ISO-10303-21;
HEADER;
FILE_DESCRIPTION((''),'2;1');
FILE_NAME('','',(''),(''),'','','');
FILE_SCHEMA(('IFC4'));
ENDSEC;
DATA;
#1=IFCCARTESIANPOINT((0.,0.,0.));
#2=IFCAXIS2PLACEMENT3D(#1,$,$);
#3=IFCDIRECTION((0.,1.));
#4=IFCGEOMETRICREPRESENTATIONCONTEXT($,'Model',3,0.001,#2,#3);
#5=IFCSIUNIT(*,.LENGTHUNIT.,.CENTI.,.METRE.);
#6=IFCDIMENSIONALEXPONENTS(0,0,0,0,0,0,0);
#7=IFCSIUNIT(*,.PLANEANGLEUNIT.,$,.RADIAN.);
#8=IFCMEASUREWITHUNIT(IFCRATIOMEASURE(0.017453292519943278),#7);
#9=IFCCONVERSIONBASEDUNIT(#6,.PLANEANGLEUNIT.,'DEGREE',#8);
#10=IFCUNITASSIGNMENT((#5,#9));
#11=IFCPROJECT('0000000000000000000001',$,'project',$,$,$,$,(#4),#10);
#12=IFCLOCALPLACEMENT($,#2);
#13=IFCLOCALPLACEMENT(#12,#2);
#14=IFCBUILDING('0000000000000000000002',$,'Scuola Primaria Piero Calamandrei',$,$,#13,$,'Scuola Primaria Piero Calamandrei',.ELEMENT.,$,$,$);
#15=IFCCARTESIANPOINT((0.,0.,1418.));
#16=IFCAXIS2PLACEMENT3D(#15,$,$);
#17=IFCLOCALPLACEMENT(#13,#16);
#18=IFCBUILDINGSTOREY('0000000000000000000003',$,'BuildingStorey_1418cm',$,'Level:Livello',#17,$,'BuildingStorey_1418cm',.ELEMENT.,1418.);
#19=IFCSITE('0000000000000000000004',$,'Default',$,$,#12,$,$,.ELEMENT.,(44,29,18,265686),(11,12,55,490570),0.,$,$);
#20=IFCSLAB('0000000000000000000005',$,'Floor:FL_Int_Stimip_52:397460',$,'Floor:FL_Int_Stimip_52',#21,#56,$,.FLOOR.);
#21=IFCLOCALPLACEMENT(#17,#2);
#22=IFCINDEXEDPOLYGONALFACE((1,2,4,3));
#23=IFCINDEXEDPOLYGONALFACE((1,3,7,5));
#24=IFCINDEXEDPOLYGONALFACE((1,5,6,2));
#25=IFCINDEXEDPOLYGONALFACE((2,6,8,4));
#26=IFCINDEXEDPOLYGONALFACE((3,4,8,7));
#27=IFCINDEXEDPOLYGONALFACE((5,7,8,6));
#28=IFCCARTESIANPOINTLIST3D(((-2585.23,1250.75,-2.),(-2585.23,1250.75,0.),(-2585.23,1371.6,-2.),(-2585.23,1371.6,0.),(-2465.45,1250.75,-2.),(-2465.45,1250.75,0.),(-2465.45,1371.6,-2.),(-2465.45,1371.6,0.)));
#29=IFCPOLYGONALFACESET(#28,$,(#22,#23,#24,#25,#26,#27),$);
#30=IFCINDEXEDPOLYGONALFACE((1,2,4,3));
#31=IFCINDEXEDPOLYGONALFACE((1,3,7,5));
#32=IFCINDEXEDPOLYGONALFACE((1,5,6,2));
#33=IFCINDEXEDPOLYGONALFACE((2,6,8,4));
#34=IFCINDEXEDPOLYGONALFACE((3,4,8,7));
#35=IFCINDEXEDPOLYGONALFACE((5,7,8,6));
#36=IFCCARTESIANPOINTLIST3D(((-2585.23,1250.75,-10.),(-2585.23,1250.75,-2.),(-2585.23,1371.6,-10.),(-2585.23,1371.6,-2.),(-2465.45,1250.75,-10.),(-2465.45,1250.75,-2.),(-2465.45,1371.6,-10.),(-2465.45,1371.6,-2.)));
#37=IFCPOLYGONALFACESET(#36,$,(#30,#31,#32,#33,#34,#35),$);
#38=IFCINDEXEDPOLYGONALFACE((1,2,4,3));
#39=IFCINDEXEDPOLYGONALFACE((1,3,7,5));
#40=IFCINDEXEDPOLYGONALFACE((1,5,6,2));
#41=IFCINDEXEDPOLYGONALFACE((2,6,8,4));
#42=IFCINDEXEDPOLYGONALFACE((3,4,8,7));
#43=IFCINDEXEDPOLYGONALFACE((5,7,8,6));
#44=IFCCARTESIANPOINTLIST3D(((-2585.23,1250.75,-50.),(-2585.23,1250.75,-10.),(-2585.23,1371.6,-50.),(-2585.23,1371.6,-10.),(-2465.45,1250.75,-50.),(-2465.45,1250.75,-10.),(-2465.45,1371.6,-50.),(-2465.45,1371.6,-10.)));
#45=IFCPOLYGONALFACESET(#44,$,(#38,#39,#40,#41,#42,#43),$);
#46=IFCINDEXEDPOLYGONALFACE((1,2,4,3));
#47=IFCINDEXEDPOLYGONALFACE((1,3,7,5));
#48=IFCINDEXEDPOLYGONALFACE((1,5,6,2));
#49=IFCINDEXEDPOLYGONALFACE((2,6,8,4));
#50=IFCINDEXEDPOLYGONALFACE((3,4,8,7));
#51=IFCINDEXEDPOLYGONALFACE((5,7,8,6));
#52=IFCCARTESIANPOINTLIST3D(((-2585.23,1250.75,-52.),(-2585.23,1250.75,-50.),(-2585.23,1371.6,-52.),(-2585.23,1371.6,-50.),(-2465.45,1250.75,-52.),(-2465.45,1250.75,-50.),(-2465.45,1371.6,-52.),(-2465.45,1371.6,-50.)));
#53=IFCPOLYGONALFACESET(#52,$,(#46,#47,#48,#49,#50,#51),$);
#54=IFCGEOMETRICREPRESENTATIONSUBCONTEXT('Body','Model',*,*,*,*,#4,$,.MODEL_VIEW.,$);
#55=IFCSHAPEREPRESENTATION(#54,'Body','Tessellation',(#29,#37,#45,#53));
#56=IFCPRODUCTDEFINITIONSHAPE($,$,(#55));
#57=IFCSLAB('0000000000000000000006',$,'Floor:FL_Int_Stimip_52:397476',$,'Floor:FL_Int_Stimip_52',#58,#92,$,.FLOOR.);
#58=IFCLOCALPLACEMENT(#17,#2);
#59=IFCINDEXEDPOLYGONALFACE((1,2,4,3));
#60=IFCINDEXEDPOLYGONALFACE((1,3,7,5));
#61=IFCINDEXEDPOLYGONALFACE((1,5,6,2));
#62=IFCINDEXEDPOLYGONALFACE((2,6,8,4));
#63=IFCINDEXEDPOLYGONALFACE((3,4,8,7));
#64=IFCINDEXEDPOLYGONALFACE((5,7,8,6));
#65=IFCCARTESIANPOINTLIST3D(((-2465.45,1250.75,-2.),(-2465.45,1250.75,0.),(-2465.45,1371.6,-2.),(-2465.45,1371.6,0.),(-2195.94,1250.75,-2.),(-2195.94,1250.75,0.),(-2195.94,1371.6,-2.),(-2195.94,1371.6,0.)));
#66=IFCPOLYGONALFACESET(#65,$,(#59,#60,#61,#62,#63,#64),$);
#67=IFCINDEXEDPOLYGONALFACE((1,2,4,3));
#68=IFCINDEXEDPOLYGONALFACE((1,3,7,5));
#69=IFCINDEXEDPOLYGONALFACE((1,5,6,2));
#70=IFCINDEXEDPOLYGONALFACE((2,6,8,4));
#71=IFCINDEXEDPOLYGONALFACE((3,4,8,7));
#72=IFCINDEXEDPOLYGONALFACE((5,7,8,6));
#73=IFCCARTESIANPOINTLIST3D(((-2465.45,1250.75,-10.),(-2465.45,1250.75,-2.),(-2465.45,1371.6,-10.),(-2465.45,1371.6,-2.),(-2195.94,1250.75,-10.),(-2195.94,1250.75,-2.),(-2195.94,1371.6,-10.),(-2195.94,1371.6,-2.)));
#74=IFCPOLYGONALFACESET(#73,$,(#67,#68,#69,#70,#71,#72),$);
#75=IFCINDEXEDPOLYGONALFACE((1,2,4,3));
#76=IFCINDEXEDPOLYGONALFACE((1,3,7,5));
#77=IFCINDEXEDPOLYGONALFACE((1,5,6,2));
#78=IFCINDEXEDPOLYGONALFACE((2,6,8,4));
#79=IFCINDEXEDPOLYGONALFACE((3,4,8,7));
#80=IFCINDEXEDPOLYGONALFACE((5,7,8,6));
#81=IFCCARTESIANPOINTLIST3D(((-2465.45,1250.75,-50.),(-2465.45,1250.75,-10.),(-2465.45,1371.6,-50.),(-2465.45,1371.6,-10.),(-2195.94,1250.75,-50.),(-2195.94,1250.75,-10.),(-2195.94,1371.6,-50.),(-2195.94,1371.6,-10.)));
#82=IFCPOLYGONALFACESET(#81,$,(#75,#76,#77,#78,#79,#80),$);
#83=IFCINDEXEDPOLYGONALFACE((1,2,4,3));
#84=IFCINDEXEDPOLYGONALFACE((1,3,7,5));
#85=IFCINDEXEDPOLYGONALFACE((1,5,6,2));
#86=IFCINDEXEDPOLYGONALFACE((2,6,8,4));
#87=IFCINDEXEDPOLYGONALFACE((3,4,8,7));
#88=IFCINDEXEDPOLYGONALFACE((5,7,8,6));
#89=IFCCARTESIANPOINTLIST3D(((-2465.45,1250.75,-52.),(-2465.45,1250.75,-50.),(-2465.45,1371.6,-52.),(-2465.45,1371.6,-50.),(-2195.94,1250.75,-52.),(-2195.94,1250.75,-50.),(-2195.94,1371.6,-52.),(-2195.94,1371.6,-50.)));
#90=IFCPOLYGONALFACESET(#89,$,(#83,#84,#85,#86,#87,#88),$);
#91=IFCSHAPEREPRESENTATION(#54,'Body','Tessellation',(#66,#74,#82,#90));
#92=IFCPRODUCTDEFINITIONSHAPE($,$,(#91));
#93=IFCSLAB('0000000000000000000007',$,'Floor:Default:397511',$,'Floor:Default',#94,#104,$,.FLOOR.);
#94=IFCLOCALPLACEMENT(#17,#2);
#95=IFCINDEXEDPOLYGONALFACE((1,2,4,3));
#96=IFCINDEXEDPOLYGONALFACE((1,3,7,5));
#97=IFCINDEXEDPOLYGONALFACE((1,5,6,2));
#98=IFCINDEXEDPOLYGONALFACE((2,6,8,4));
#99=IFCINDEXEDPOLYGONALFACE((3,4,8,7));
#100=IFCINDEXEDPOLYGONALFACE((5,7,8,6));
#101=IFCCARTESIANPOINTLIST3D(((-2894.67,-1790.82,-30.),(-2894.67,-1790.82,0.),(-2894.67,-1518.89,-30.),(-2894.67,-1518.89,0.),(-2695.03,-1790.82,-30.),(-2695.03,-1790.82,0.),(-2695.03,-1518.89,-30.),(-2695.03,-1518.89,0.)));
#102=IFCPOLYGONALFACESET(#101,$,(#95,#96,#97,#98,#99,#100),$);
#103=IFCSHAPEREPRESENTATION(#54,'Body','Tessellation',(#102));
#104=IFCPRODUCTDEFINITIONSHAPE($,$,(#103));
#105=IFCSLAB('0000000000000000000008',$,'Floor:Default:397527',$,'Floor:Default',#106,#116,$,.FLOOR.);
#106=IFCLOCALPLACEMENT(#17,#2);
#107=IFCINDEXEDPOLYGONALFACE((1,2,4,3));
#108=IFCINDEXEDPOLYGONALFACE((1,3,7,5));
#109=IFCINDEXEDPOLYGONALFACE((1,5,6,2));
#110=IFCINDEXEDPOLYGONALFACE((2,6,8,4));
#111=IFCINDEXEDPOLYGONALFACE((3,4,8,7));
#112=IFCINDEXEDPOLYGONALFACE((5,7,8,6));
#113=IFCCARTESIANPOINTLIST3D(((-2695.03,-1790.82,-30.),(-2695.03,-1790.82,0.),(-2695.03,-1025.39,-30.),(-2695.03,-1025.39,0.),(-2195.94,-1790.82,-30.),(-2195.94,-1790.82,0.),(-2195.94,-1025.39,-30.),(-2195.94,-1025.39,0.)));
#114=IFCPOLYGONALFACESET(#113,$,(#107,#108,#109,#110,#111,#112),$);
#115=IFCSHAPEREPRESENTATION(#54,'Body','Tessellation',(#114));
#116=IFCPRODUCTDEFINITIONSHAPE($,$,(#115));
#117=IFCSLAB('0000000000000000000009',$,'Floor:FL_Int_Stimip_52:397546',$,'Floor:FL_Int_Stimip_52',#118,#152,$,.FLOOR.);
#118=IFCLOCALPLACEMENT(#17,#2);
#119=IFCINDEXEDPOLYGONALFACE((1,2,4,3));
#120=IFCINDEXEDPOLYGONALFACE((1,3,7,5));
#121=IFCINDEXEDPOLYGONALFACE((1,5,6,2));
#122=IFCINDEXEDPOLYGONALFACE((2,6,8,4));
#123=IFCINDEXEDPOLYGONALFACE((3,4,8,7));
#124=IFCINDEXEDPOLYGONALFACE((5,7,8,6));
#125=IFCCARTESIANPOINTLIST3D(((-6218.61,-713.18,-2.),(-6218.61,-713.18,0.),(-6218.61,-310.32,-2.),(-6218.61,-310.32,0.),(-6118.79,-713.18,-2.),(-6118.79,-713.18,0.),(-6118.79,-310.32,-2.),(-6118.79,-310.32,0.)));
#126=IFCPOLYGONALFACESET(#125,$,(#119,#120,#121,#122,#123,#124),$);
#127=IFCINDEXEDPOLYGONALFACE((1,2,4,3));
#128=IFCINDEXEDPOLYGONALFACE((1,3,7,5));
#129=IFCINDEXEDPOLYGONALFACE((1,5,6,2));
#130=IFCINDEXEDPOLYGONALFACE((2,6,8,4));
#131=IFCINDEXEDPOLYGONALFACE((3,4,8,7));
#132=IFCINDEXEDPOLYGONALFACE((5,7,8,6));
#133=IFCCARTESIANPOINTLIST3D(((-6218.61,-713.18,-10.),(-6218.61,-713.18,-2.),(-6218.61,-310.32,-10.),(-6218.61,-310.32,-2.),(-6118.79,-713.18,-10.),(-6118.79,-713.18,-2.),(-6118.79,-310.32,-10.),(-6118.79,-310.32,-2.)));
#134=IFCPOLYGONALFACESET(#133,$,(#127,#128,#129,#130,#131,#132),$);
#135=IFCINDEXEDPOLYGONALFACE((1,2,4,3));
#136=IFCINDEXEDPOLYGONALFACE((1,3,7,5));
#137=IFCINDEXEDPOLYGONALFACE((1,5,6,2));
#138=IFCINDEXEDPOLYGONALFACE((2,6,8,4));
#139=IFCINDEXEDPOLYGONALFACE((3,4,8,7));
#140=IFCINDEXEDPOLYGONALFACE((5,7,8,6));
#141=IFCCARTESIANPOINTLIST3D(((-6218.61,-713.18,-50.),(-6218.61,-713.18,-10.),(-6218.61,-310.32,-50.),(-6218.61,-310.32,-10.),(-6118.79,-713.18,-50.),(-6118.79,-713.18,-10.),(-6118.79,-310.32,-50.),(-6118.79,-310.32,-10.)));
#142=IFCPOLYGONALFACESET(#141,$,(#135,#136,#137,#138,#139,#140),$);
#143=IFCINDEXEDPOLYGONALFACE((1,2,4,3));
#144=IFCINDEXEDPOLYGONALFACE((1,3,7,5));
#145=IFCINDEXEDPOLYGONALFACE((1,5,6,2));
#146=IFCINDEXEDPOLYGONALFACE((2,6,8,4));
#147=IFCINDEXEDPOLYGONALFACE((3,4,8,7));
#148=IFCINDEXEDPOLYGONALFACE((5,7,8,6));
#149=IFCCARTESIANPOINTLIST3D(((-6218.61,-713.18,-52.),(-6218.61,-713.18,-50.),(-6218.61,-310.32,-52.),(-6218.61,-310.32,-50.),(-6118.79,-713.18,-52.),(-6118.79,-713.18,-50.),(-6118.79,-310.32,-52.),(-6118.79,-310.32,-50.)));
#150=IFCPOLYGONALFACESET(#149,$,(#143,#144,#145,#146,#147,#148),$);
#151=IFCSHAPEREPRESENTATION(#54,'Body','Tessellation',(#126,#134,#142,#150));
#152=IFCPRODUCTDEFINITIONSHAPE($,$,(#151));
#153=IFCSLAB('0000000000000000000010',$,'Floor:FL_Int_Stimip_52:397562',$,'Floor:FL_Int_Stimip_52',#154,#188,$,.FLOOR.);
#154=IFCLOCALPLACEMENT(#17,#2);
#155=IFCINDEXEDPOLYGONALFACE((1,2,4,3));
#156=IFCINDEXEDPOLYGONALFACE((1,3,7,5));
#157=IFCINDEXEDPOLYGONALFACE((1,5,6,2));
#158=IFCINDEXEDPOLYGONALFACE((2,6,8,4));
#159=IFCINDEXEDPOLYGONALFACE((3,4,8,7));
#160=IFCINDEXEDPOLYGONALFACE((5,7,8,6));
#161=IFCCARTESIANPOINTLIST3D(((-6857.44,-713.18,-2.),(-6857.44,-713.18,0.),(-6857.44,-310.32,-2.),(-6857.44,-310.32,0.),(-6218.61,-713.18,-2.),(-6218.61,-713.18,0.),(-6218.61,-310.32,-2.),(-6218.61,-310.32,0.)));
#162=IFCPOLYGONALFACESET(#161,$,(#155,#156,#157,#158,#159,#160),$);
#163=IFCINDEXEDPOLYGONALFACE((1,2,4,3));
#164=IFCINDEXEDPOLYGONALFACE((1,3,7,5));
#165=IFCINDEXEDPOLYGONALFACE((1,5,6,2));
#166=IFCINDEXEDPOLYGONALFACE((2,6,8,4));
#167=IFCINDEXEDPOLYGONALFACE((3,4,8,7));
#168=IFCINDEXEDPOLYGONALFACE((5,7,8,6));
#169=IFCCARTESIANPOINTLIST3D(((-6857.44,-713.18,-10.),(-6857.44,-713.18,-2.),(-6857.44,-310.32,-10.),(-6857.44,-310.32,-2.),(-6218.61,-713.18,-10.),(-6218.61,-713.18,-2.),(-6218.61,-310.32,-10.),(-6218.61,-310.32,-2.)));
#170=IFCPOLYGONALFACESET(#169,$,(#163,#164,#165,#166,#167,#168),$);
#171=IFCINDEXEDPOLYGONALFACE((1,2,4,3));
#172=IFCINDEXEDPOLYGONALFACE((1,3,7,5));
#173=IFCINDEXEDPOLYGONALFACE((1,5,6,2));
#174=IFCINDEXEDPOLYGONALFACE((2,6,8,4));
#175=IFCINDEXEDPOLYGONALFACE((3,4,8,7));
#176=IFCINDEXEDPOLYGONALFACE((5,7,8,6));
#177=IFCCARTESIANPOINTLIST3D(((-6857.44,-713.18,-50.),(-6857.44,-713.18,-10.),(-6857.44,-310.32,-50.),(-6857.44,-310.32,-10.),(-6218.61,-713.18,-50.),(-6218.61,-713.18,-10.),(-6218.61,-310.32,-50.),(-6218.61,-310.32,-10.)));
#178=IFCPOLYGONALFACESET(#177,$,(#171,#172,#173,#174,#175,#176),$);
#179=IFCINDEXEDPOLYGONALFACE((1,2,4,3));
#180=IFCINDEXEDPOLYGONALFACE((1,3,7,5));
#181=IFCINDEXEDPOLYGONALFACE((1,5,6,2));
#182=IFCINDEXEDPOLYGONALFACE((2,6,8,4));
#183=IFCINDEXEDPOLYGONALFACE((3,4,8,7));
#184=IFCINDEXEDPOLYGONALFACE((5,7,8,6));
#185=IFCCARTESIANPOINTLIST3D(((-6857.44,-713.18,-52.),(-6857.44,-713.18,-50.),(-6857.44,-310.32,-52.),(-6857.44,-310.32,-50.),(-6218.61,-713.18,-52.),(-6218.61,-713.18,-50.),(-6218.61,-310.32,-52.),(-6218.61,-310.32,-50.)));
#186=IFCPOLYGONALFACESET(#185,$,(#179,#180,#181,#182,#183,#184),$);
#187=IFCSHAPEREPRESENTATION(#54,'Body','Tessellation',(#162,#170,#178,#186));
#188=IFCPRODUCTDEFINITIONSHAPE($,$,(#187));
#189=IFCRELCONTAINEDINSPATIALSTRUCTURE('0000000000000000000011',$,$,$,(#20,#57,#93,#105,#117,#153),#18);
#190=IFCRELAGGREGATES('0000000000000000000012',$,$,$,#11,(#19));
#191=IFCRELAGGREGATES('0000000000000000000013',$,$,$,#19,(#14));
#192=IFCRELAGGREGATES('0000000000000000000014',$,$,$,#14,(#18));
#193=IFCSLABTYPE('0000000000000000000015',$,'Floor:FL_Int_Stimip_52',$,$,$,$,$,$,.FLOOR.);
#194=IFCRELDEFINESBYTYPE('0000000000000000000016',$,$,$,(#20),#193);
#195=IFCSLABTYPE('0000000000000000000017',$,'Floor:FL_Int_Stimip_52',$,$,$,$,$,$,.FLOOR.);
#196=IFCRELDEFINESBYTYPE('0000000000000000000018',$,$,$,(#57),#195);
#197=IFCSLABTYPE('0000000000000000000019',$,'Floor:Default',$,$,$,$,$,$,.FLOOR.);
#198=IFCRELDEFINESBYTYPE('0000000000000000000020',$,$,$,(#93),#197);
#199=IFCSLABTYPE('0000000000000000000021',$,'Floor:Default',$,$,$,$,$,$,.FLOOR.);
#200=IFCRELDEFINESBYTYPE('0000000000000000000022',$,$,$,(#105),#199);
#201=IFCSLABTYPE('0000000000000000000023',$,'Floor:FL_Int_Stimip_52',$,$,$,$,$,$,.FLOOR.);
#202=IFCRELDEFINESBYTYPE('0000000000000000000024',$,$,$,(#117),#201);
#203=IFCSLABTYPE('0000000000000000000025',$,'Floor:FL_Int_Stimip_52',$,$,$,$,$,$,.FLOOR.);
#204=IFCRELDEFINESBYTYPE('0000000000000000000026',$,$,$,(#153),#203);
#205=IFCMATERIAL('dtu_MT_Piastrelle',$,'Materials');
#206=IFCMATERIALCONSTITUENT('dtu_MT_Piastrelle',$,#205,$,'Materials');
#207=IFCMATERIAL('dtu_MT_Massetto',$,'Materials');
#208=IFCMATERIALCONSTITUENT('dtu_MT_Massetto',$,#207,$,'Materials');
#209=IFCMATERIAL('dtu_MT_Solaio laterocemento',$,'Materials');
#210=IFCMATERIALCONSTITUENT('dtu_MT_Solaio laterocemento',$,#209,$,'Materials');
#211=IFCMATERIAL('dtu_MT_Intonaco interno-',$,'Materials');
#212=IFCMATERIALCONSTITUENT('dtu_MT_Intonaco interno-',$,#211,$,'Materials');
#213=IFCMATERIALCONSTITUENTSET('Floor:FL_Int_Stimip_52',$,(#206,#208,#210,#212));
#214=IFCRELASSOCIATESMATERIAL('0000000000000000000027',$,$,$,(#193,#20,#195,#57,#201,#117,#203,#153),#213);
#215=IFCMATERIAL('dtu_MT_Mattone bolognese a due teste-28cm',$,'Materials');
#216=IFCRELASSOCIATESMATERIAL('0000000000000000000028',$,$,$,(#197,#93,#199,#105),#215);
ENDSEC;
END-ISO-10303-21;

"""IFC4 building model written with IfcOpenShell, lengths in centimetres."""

from ifc_helpers import new_model, entity, si_unit, converted_unit, direction, frame, origin, place, context, subcontext, project, spatial, indexed_curve, outline, extrude, material, constituent, constituent_set, type_object, element, save


model = new_model("IFC4")

# Units and contexts
model_context = context("Model", 3, precision=0.001, world=origin(), true_north=direction((0.0, 1.0)))
body_context = subcontext(model_context, "Body", "Model", "MODEL_VIEW")
ifc_project = project(units=[si_unit("LENGTHUNIT", "METRE", prefix="CENTI"), converted_unit("PLANEANGLEUNIT", "DEGREE", entity("IfcRatioMeasure", 0.017453292519943278), si_unit("PLANEANGLEUNIT", "RADIAN"), dimensions=[0, 0, 0, 0, 0, 0, 0])], contexts=[model_context])

# Site, building, storey
site_placement = place(None, origin())
site = spatial("IfcSite", under=ifc_project, at=site_placement, Name="Default", CompositionType="ELEMENT", RefLatitude=(44, 29, 18, 265686), RefLongitude=(11, 12, 55, 490570), RefElevation=0.0)
building_placement = place(site_placement, origin())
building = spatial("IfcBuilding", under=site, at=building_placement, Name="Scuola Primaria Piero Calamandrei", LongName="Scuola Primaria Piero Calamandrei", CompositionType="ELEMENT")
storey_placement = place(building_placement, frame((0.0, 0.0, 1418.0)))
storey = spatial("IfcBuildingStorey", under=building, at=storey_placement, Name="BuildingStorey_1418cm", ObjectType="Level:Livello", LongName="BuildingStorey_1418cm", CompositionType="ELEMENT", Elevation=1418.0)

# Slabs
ifc_material_1 = material(Name="dtu_MT_Piastrelle", Category="Materials")
ifc_constituent_1 = constituent(ifc_material_1, Name="dtu_MT_Piastrelle", Category="Materials")
ifc_material_2 = material(Name="dtu_MT_Massetto", Category="Materials")
ifc_constituent_2 = constituent(ifc_material_2, Name="dtu_MT_Massetto", Category="Materials")
ifc_material_3 = material(Name="dtu_MT_Solaio laterocemento", Category="Materials")
ifc_constituent_3 = constituent(ifc_material_3, Name="dtu_MT_Solaio laterocemento", Category="Materials")
ifc_material_4 = material(Name="dtu_MT_Intonaco interno-", Category="Materials")
ifc_constituent_4 = constituent(ifc_material_4, Name="dtu_MT_Intonaco interno-", Category="Materials")
ifc_constituent_set = constituent_set(constituents=[ifc_constituent_1, ifc_constituent_2, ifc_constituent_3, ifc_constituent_4], Name="Floor:FL_Int_Stimip_52")
slab_type_1 = type_object("IfcSlabType", Name="Floor:FL_Int_Stimip_52", PredefinedType="FLOOR", material=ifc_constituent_set)
slab_1_placement = place(storey_placement, origin())
element("IfcSlab", 1, at=slab_1_placement, inside=storey, type_object=slab_type_1, material=ifc_constituent_set, Name="Floor:FL_Int_Stimip_52:397460", ObjectType="Floor:FL_Int_Stimip_52", PredefinedType="FLOOR", context=body_context, shape_type="SweptSolid", body=[
    extrude(outline(indexed_curve([(-60.43, -59.89), (60.43, -59.89), (60.43, 59.89), (-60.43, 59.89), (-60.43, -59.89)], self_intersect=False)), frame((-2525.34, 1311.17, -2.0), z_axis=(0.0, 0.0, 1.0), x_axis=(0.0, 1.0, 0.0)), (0.0, 0.0, 1.0), 2.0),
    extrude(outline(indexed_curve([(-60.43, -59.89), (60.43, -59.89), (60.43, 59.89), (-60.43, 59.89), (-60.43, -59.89)], self_intersect=False)), frame((-2525.34, 1311.17, -10.0), z_axis=(0.0, 0.0, 1.0), x_axis=(0.0, 1.0, 0.0)), (0.0, 0.0, 1.0), 8.0),
    extrude(outline(indexed_curve([(-60.43, -59.89), (60.43, -59.89), (60.43, 59.89), (-60.43, 59.89), (-60.43, -59.89)], self_intersect=False)), frame((-2525.34, 1311.17, -50.0), z_axis=(0.0, 0.0, 1.0), x_axis=(0.0, 1.0, 0.0)), (0.0, 0.0, 1.0), 40.0),
    extrude(outline(indexed_curve([(-60.43, -59.89), (60.43, -59.89), (60.43, 59.89), (-60.43, 59.89), (-60.43, -59.89)], self_intersect=False)), frame((-2525.34, 1311.17, -52.0), z_axis=(0.0, 0.0, 1.0), x_axis=(0.0, 1.0, 0.0)), (0.0, 0.0, 1.0), 2.0),
])
slab_type_2 = type_object("IfcSlabType", Name="Floor:FL_Int_Stimip_52", PredefinedType="FLOOR", material=ifc_constituent_set)
slab_2_placement = place(storey_placement, origin())
element("IfcSlab", 2, at=slab_2_placement, inside=storey, type_object=slab_type_2, material=ifc_constituent_set, Name="Floor:FL_Int_Stimip_52:397476", ObjectType="Floor:FL_Int_Stimip_52", PredefinedType="FLOOR", context=body_context, shape_type="SweptSolid", body=[
    extrude(outline(indexed_curve([(-134.75, -60.43), (134.75, -60.43), (134.75, 60.43), (-134.75, 60.43), (-134.75, -60.43)], self_intersect=False)), frame((-2330.69, 1311.17, -2.0)), (0.0, 0.0, 1.0), 2.0),
    extrude(outline(indexed_curve([(-134.75, -60.43), (134.75, -60.43), (134.75, 60.43), (-134.75, 60.43), (-134.75, -60.43)], self_intersect=False)), frame((-2330.69, 1311.17, -10.0)), (0.0, 0.0, 1.0), 8.0),
    extrude(outline(indexed_curve([(-134.75, -60.43), (134.75, -60.43), (134.75, 60.43), (-134.75, 60.43), (-134.75, -60.43)], self_intersect=False)), frame((-2330.69, 1311.17, -50.0)), (0.0, 0.0, 1.0), 40.0),
    extrude(outline(indexed_curve([(-134.75, -60.43), (134.75, -60.43), (134.75, 60.43), (-134.75, 60.43), (-134.75, -60.43)], self_intersect=False)), frame((-2330.69, 1311.17, -52.0)), (0.0, 0.0, 1.0), 2.0),
])
ifc_material_5 = material(Name="dtu_MT_Mattone bolognese a due teste-28cm", Category="Materials")
slab_type_3 = type_object("IfcSlabType", Name="Floor:Default", PredefinedType="FLOOR", material=ifc_material_5)
slab_3_placement = place(storey_placement, origin())
element("IfcSlab", 3, at=slab_3_placement, inside=storey, type_object=slab_type_3, material=ifc_material_5, Name="Floor:Default:397511", ObjectType="Floor:Default", PredefinedType="FLOOR", context=body_context, shape_type="SweptSolid", body=[
    extrude(outline(indexed_curve([(-135.96, -99.82), (135.96, -99.82), (135.96, 99.82), (-135.96, 99.82), (-135.96, -99.82)], self_intersect=False)), frame((-2794.85, -1654.86, 0.0), z_axis=(0.0, 0.0, -1.0), x_axis=(0.0, 1.0, 0.0)), (0.0, 0.0, 1.0), 30.0),
])
slab_type_4 = type_object("IfcSlabType", Name="Floor:Default", PredefinedType="FLOOR", material=ifc_material_5)
slab_4_placement = place(storey_placement, origin())
element("IfcSlab", 4, at=slab_4_placement, inside=storey, type_object=slab_type_4, material=ifc_material_5, Name="Floor:Default:397527", ObjectType="Floor:Default", PredefinedType="FLOOR", context=body_context, shape_type="SweptSolid", body=[
    extrude(outline(indexed_curve([(-249.55, -382.71), (249.55, -382.71), (249.55, 382.71), (-249.55, 382.71), (-249.55, -382.71)], self_intersect=False)), frame((-2445.49, -1408.11, 0.0), z_axis=(0.0, 0.0, -1.0), x_axis=(1.0, 0.0, 0.0)), (0.0, 0.0, 1.0), 30.0),
])
slab_type_5 = type_object("IfcSlabType", Name="Floor:FL_Int_Stimip_52", PredefinedType="FLOOR", material=ifc_constituent_set)
slab_5_placement = place(storey_placement, origin())
element("IfcSlab", 5, at=slab_5_placement, inside=storey, type_object=slab_type_5, material=ifc_constituent_set, Name="Floor:FL_Int_Stimip_52:397546", ObjectType="Floor:FL_Int_Stimip_52", PredefinedType="FLOOR", context=body_context, shape_type="SweptSolid", body=[
    extrude(outline(indexed_curve([(-49.91, -201.43), (49.91, -201.43), (49.91, 201.43), (-49.91, 201.43), (-49.91, -201.43)], self_intersect=False)), frame((-6168.7, -511.75, -2.0)), (0.0, 0.0, 1.0), 2.0),
    extrude(outline(indexed_curve([(-49.91, -201.43), (49.91, -201.43), (49.91, 201.43), (-49.91, 201.43), (-49.91, -201.43)], self_intersect=False)), frame((-6168.7, -511.75, -10.0)), (0.0, 0.0, 1.0), 8.0),
    extrude(outline(indexed_curve([(-49.91, -201.43), (49.91, -201.43), (49.91, 201.43), (-49.91, 201.43), (-49.91, -201.43)], self_intersect=False)), frame((-6168.7, -511.75, -50.0)), (0.0, 0.0, 1.0), 40.0),
    extrude(outline(indexed_curve([(-49.91, -201.43), (49.91, -201.43), (49.91, 201.43), (-49.91, 201.43), (-49.91, -201.43)], self_intersect=False)), frame((-6168.7, -511.75, -52.0)), (0.0, 0.0, 1.0), 2.0),
])
slab_type_6 = type_object("IfcSlabType", Name="Floor:FL_Int_Stimip_52", PredefinedType="FLOOR", material=ifc_constituent_set)
slab_6_placement = place(storey_placement, origin())
element("IfcSlab", 6, at=slab_6_placement, inside=storey, type_object=slab_type_6, material=ifc_constituent_set, Name="Floor:FL_Int_Stimip_52:397562", ObjectType="Floor:FL_Int_Stimip_52", PredefinedType="FLOOR", context=body_context, shape_type="SweptSolid", body=[
    extrude(outline(indexed_curve([(-319.42, -201.43), (319.42, -201.43), (319.42, 201.43), (-319.42, 201.43), (-319.42, -201.43)], self_intersect=False)), frame((-6538.03, -511.75, -2.0)), (0.0, 0.0, 1.0), 2.0),
    extrude(outline(indexed_curve([(-319.42, -201.43), (319.42, -201.43), (319.42, 201.43), (-319.42, 201.43), (-319.42, -201.43)], self_intersect=False)), frame((-6538.03, -511.75, -10.0)), (0.0, 0.0, 1.0), 8.0),
    extrude(outline(indexed_curve([(-319.42, -201.43), (319.42, -201.43), (319.42, 201.43), (-319.42, 201.43), (-319.42, -201.43)], self_intersect=False)), frame((-6538.03, -511.75, -50.0)), (0.0, 0.0, 1.0), 40.0),
    extrude(outline(indexed_curve([(-319.42, -201.43), (319.42, -201.43), (319.42, 201.43), (-319.42, 201.43), (-319.42, -201.43)], self_intersect=False)), frame((-6538.03, -511.75, -52.0)), (0.0, 0.0, 1.0), 2.0),
])

save(model, "model.ifc")
